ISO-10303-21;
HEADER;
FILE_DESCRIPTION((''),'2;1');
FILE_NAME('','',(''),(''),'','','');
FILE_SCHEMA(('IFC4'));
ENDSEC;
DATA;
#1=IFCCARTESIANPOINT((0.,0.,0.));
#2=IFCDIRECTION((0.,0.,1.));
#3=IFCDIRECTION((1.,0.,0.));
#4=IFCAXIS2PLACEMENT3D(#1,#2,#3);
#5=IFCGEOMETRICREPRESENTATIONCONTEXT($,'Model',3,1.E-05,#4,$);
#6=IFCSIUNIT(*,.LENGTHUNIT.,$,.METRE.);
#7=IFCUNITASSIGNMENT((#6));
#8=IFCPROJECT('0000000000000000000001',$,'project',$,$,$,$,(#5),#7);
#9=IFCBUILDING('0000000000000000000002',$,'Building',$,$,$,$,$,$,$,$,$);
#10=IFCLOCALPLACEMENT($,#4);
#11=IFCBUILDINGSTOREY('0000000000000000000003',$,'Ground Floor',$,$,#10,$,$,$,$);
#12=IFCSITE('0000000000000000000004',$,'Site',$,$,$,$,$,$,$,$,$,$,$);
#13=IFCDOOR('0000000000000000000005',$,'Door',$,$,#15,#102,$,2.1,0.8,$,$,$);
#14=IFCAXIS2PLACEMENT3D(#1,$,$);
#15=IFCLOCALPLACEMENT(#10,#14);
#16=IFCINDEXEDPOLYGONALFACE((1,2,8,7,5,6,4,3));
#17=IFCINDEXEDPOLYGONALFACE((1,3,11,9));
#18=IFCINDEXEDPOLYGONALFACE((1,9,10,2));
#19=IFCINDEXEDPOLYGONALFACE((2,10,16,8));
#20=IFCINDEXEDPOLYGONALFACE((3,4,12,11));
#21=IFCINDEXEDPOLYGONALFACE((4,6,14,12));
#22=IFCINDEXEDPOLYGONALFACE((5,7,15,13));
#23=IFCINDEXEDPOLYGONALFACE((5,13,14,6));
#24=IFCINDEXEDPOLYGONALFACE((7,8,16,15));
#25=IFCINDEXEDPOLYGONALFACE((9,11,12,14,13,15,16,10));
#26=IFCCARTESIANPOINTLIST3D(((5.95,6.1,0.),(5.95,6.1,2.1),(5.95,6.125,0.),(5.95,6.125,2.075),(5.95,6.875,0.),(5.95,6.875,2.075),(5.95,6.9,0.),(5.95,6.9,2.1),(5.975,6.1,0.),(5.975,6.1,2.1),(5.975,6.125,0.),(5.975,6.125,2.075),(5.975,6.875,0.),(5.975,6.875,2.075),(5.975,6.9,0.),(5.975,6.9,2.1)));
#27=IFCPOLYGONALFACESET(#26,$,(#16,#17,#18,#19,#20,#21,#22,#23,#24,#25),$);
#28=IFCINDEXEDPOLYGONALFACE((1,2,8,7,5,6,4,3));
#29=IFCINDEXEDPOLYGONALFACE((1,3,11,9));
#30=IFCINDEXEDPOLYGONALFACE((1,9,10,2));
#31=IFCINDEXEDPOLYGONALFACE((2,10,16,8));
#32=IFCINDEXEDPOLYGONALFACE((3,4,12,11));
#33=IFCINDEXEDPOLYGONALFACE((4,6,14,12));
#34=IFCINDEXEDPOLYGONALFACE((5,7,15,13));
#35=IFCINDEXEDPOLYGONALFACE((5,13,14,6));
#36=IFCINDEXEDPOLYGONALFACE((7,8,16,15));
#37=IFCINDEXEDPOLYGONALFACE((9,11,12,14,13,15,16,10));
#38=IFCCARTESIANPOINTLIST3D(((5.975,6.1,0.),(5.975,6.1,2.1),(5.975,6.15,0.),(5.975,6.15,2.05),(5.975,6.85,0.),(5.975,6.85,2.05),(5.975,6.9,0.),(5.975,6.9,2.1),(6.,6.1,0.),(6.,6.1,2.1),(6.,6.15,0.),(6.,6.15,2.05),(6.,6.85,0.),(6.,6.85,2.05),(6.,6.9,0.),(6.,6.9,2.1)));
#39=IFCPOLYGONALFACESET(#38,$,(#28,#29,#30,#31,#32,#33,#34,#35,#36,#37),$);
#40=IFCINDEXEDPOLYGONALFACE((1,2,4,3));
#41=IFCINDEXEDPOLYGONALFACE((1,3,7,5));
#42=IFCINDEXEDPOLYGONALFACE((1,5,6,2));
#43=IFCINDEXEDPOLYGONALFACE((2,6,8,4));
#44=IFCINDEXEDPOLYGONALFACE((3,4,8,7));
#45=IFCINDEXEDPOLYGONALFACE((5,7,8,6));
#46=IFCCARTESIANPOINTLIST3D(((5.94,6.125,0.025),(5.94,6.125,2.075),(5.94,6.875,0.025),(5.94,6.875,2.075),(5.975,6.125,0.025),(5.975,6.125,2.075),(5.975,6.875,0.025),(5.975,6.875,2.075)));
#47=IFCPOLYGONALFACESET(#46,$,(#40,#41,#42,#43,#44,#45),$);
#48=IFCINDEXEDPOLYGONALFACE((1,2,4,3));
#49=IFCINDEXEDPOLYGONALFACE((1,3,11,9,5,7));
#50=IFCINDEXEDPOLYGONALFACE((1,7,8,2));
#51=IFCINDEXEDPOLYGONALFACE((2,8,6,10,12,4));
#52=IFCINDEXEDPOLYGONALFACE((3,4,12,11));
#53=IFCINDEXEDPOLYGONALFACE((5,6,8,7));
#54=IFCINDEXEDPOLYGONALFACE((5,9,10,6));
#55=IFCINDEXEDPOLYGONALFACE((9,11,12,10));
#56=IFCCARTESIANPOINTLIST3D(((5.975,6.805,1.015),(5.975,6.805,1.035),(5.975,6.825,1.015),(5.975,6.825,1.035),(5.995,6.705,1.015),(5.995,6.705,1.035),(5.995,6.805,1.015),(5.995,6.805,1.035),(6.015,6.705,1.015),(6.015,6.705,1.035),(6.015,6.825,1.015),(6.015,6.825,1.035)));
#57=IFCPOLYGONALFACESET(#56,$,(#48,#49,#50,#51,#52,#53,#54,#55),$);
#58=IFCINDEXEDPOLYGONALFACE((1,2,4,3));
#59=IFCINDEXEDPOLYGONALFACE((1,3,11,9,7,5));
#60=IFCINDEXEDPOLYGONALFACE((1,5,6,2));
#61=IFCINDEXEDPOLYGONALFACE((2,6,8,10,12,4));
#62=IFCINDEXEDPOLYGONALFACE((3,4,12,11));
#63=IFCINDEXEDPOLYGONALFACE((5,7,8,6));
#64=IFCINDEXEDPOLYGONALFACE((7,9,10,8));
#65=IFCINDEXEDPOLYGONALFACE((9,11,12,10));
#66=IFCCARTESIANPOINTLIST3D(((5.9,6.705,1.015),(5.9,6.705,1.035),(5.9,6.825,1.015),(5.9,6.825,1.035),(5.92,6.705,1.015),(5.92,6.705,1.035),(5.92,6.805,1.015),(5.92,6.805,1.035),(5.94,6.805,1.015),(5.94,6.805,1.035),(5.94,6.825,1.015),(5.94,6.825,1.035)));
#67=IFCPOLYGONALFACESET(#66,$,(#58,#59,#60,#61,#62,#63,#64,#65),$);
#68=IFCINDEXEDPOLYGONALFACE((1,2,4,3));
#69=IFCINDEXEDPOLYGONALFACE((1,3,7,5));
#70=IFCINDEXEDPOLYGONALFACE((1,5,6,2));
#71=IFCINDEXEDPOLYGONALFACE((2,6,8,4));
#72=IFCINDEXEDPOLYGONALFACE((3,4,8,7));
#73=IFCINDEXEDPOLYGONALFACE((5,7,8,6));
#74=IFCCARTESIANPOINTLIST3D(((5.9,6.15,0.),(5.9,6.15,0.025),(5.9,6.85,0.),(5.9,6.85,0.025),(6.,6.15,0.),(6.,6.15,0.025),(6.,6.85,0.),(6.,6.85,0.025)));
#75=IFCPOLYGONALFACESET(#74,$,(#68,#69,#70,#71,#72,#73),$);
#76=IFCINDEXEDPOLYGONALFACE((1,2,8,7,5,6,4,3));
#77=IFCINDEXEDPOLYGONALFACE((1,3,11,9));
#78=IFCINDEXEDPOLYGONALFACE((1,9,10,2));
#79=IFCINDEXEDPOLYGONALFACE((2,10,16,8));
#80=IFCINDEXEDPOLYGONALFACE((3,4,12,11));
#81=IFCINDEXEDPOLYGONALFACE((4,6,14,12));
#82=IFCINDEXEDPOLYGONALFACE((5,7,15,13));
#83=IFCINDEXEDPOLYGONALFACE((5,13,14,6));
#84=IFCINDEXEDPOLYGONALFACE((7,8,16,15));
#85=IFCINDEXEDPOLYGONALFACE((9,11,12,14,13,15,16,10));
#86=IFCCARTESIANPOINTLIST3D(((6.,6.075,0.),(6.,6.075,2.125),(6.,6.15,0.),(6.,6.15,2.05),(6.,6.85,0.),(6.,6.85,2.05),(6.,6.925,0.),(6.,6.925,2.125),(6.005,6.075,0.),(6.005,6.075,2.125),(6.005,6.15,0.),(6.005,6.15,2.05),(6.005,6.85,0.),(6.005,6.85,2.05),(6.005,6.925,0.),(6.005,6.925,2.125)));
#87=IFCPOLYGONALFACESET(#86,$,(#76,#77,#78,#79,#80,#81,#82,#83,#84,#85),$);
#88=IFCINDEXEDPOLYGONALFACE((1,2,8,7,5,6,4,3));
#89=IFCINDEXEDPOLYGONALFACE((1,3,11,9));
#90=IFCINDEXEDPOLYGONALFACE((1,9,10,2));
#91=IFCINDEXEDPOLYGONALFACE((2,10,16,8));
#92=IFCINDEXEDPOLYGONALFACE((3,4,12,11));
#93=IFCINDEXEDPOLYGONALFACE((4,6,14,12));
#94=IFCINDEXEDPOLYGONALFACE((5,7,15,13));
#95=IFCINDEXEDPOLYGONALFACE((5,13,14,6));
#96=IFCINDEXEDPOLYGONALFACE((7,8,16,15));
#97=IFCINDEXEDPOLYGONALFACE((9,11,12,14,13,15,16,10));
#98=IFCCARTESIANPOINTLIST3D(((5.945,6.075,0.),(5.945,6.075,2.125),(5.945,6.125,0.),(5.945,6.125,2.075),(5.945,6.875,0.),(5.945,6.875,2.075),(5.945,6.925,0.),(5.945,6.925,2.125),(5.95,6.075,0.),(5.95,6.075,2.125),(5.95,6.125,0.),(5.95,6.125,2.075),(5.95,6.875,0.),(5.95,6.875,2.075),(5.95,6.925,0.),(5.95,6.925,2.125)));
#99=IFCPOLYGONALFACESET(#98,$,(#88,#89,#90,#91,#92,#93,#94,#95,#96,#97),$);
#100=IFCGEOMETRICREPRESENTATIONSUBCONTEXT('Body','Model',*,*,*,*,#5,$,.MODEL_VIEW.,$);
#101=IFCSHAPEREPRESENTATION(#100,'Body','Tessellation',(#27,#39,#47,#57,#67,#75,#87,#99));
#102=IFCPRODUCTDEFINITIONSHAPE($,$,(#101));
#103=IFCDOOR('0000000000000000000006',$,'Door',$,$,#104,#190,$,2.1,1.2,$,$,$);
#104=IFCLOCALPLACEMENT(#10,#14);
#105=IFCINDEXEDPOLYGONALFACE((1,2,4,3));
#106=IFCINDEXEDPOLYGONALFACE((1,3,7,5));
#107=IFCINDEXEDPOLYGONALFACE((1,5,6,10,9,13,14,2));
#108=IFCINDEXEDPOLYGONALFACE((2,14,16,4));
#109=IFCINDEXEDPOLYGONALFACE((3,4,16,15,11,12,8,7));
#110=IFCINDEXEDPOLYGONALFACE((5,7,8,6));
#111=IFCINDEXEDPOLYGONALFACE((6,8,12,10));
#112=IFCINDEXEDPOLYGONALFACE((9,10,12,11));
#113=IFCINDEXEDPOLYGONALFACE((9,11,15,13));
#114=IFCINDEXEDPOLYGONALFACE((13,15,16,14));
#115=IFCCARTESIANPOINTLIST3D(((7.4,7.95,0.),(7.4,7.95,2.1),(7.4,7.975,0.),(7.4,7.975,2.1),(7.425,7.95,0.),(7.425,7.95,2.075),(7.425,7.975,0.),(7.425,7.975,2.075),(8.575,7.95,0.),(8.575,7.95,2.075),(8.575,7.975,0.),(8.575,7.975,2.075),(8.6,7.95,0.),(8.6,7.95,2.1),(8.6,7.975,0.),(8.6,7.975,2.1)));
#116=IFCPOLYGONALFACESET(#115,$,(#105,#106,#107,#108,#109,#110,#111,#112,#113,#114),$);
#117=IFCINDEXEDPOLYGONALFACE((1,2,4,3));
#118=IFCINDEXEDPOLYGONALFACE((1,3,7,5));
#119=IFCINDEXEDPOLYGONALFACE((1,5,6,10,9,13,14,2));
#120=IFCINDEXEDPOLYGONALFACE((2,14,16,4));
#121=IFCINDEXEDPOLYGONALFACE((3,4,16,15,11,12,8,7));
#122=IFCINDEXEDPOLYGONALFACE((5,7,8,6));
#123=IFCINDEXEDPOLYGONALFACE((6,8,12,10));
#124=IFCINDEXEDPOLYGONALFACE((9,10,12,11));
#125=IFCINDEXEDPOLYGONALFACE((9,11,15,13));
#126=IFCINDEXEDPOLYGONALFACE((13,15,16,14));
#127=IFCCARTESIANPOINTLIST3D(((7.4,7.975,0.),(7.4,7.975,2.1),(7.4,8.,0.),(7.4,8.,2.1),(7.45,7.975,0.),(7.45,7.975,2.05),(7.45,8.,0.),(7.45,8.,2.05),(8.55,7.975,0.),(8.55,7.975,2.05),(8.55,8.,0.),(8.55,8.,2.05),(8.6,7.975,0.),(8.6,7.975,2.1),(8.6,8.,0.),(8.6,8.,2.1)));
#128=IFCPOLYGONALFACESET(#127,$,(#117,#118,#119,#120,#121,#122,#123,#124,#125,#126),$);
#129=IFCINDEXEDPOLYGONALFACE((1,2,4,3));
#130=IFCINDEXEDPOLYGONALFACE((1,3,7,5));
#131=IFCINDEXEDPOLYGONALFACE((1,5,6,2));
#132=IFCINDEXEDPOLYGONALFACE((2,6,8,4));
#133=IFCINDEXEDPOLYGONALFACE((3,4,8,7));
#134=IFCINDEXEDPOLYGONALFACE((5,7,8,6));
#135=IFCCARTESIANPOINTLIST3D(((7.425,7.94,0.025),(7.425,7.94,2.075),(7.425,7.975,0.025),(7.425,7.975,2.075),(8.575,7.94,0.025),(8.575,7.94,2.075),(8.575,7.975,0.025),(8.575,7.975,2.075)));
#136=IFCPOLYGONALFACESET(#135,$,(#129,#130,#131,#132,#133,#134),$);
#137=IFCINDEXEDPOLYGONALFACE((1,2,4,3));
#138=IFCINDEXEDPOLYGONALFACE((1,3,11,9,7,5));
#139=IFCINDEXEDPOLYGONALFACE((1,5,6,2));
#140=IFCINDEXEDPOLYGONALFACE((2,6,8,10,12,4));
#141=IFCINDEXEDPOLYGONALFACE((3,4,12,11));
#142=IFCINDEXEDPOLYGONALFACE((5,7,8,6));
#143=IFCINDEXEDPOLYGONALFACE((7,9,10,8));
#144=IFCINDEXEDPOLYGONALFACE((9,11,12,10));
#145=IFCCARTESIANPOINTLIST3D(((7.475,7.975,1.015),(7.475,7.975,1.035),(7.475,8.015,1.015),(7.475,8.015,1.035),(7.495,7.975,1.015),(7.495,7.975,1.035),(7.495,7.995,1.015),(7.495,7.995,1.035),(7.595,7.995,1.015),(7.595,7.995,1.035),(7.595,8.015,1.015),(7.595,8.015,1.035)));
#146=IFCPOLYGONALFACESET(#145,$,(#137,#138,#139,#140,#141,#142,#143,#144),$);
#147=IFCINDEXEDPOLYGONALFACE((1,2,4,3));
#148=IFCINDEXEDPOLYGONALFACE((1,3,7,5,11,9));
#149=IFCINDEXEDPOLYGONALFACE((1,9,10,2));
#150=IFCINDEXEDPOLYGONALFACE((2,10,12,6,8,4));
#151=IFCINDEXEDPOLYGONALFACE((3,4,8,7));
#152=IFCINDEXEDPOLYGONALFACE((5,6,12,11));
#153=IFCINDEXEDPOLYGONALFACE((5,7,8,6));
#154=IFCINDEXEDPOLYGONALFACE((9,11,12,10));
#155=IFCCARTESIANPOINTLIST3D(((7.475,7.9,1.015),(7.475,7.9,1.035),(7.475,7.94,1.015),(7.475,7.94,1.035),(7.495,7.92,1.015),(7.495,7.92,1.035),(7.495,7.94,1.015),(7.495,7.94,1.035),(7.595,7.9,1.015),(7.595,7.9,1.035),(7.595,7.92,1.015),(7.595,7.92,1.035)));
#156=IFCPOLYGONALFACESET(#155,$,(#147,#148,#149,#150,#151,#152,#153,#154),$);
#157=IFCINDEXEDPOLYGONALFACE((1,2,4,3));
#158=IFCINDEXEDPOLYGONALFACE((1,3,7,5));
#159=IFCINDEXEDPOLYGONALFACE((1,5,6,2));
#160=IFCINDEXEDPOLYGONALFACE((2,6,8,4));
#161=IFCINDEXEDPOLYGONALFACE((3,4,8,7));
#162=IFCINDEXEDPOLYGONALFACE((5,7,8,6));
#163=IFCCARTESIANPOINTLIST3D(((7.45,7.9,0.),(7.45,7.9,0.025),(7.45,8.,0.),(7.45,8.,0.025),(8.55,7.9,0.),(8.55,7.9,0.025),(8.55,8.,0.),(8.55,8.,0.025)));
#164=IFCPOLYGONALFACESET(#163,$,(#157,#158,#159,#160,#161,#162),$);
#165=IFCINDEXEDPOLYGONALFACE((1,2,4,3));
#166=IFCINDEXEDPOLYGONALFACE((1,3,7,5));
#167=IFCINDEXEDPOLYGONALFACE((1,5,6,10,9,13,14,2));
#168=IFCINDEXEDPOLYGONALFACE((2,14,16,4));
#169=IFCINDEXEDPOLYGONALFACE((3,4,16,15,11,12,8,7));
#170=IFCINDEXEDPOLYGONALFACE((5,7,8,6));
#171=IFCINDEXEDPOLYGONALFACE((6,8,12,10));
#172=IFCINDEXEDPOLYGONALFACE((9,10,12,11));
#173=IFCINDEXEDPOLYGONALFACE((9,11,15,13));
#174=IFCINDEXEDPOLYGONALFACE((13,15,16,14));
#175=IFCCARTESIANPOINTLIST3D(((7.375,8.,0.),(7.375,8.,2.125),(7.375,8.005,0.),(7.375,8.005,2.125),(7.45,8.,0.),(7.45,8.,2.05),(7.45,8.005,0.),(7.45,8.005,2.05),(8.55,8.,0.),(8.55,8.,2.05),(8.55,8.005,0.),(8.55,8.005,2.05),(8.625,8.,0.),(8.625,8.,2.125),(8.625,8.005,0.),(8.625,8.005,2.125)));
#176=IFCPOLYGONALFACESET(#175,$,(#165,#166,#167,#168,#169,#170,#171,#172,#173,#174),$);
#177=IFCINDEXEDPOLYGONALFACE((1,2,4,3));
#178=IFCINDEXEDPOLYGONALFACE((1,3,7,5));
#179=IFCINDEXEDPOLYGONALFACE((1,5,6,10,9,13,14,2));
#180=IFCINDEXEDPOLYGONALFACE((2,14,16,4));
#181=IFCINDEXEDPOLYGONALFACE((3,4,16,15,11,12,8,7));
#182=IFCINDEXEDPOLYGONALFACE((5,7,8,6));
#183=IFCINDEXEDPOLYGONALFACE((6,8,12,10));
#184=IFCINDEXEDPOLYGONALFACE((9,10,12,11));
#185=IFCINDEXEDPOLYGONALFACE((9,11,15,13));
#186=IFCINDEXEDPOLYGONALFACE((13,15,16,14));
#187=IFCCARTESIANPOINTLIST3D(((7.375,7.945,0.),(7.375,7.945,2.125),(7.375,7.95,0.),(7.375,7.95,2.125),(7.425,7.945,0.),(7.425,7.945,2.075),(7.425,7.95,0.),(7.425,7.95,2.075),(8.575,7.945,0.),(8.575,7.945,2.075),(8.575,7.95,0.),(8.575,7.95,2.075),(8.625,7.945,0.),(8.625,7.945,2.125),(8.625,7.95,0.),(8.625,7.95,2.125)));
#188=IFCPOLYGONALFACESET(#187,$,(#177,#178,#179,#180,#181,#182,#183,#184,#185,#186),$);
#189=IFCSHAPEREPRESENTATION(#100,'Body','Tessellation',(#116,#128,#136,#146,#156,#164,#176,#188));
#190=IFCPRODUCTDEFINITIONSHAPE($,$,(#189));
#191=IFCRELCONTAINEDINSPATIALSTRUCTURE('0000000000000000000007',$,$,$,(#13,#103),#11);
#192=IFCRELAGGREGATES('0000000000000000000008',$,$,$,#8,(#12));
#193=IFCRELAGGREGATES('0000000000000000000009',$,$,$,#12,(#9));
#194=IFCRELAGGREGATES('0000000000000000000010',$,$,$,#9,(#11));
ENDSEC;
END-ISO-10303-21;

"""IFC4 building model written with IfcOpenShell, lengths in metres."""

from ifc_helpers import new_model, si_unit, frame, origin_with_axes, place, context, subcontext, project, spatial, line, indexed_curve, outline, extrude, element, save


model = new_model("IFC4")

# Units and contexts
model_context = context("Model", 3, precision=1e-05, world=origin_with_axes())
body_context = subcontext(model_context, "Body", "Model", "MODEL_VIEW")
ifc_project = project(units=[si_unit("LENGTHUNIT", "METRE")], contexts=[model_context])

# Site, building, storey
site = spatial("IfcSite", under=ifc_project, Name="Site")
building = spatial("IfcBuilding", under=site, Name="Building")
storey_placement = place(None, origin_with_axes())
storey = spatial("IfcBuildingStorey", under=building, at=storey_placement, Name="Ground Floor")

# Doors
door_1_placement = place(storey_placement, frame((6.0, 6.1, 0.0), z_axis=(0.0, 0.0, 1.0), x_axis=(0.0, 1.0, 0.0)))
element("IfcDoor", 1, at=door_1_placement, inside=storey, Name="Door", OverallHeight=2.1, OverallWidth=0.8, context=body_context, shape_type="SweptSolid", body=[
    extrude(outline(indexed_curve([(0.0, 0.0), (0.0, 2.1), (0.8, 2.1), (0.8, 0.0), (0.775, 0.0), (0.775, 2.075), (0.025, 2.075), (0.025, 0.0)], segments=[line(1, 2, 3, 4, 5, 6, 7, 8, 1)])), frame((0.0, 0.025, 0.0), z_axis=(0.0, -1.0, 0.0), x_axis=(1.0, 0.0, 0.0)), (0.0, 0.0, -1.0), 0.025),
    extrude(outline(indexed_curve([(0.0, 0.0), (0.0, 2.1), (0.8, 2.1), (0.8, 0.0), (0.75, 0.0), (0.75, 2.05), (0.05, 2.05), (0.05, 0.0)], segments=[line(1, 2, 3, 4, 5, 6, 7, 8, 1)])), frame((0.0, 0.0, 0.0), z_axis=(0.0, -1.0, 0.0), x_axis=(1.0, 0.0, 0.0)), (0.0, 0.0, -1.0), 0.025),
    extrude(outline(indexed_curve([(0.0, 0.0), (0.75, 0.0), (0.75, 0.035), (0.0, 0.035)], segments=[line(1, 2, 3, 4, 1)])), frame((0.025, 0.025, 0.025), z_axis=(0.0, 0.0, 1.0), x_axis=(1.0, 0.0, 0.0)), (0.0, 0.0, 1.0), 2.05),
    extrude(outline(indexed_curve([(0.0, 0.0), (0.0, -0.04), (-0.12, -0.04), (-0.12, -0.02), (-0.02, -0.02), (-0.02, 0.0)], segments=[line(1, 2, 3, 4, 5, 6, 1)])), frame((0.725, 0.025, 1.015), z_axis=(0.0, 0.0, 1.0), x_axis=(1.0, 0.0, 0.0)), (0.0, 0.0, 1.0), 0.02),
    extrude(outline(indexed_curve([(0.0, 0.0), (0.0, 0.04), (-0.12, 0.04), (-0.12, 0.02), (-0.02, 0.02), (-0.02, 0.0)], segments=[line(1, 2, 3, 4, 5, 6, 1)])), frame((0.725, 0.06, 1.015), z_axis=(0.0, 0.0, 1.0), x_axis=(1.0, 0.0, 0.0)), (0.0, 0.0, 1.0), 0.02),
    extrude(outline(indexed_curve([(0.0, 0.0), (0.7, 0.0), (0.7, 0.1), (0.0, 0.1)], segments=[line(1, 2, 3, 4, 1)])), frame((0.05, 0.0, 0.0), z_axis=(0.0, 0.0, 1.0), x_axis=(1.0, 0.0, 0.0)), (0.0, 0.0, 1.0), 0.025),
    extrude(outline(indexed_curve([(0.0, 0.0), (0.0, 2.125), (0.85, 2.125), (0.85, 0.0), (0.775, 0.0), (0.775, 2.05), (0.075, 2.05), (0.075, 0.0)], segments=[line(1, 2, 3, 4, 5, 6, 7, 8, 1)])), frame((-0.025, -0.005, 0.0), z_axis=(0.0, -1.0, 0.0), x_axis=(1.0, 0.0, 0.0)), (0.0, 0.0, -1.0), 0.005),
    extrude(outline(indexed_curve([(0.0, 0.0), (0.0, 2.125), (0.85, 2.125), (0.85, 0.0), (0.8, 0.0), (0.8, 2.075), (0.05, 2.075), (0.05, 0.0)], segments=[line(1, 2, 3, 4, 5, 6, 7, 8, 1)])), frame((-0.025, 0.05, 0.0), z_axis=(0.0, -1.0, 0.0), x_axis=(1.0, 0.0, 0.0)), (0.0, 0.0, -1.0), 0.005),
])
door_2_placement = place(storey_placement, frame((8.6, 8.0, 0.0), z_axis=(0.0, 0.0, 1.0), x_axis=(-1.0, 0.0, 0.0)))
element("IfcDoor", 2, at=door_2_placement, inside=storey, Name="Door", OverallHeight=2.1, OverallWidth=1.2, context=body_context, shape_type="SweptSolid", body=[
    extrude(outline(indexed_curve([(0.0, 0.0), (0.0, 2.1), (1.2, 2.1), (1.2, 0.0), (1.175, 0.0), (1.175, 2.075), (0.025, 2.075), (0.025, 0.0)], segments=[line(1, 2, 3, 4, 5, 6, 7, 8, 1)])), frame((0.0, 0.025, 0.0), z_axis=(0.0, -1.0, 0.0), x_axis=(1.0, 0.0, 0.0)), (0.0, 0.0, -1.0), 0.025),
    extrude(outline(indexed_curve([(0.0, 0.0), (0.0, 2.1), (1.2, 2.1), (1.2, 0.0), (1.15, 0.0), (1.15, 2.05), (0.05, 2.05), (0.05, 0.0)], segments=[line(1, 2, 3, 4, 5, 6, 7, 8, 1)])), frame((0.0, 0.0, 0.0), z_axis=(0.0, -1.0, 0.0), x_axis=(1.0, 0.0, 0.0)), (0.0, 0.0, -1.0), 0.025),
    extrude(outline(indexed_curve([(0.0, 0.0), (1.15, 0.0), (1.15, 0.035), (0.0, 0.035)], segments=[line(1, 2, 3, 4, 1)])), frame((0.025, 0.025, 0.025), z_axis=(0.0, 0.0, 1.0), x_axis=(1.0, 0.0, 0.0)), (0.0, 0.0, 1.0), 2.05),
    extrude(outline(indexed_curve([(0.0, 0.0), (0.0, -0.04), (-0.12, -0.04), (-0.12, -0.02), (-0.02, -0.02), (-0.02, 0.0)], segments=[line(1, 2, 3, 4, 5, 6, 1)])), frame((1.125, 0.025, 1.015), z_axis=(0.0, 0.0, 1.0), x_axis=(1.0, 0.0, 0.0)), (0.0, 0.0, 1.0), 0.02),
    extrude(outline(indexed_curve([(0.0, 0.0), (0.0, 0.04), (-0.12, 0.04), (-0.12, 0.02), (-0.02, 0.02), (-0.02, 0.0)], segments=[line(1, 2, 3, 4, 5, 6, 1)])), frame((1.125, 0.06, 1.015), z_axis=(0.0, 0.0, 1.0), x_axis=(1.0, 0.0, 0.0)), (0.0, 0.0, 1.0), 0.02),
    extrude(outline(indexed_curve([(0.0, 0.0), (1.1, 0.0), (1.1, 0.1), (0.0, 0.1)], segments=[line(1, 2, 3, 4, 1)])), frame((0.05, 0.0, 0.0), z_axis=(0.0, 0.0, 1.0), x_axis=(1.0, 0.0, 0.0)), (0.0, 0.0, 1.0), 0.025),
    extrude(outline(indexed_curve([(0.0, 0.0), (0.0, 2.125), (1.25, 2.125), (1.25, 0.0), (1.175, 0.0), (1.175, 2.05), (0.075, 2.05), (0.075, 0.0)], segments=[line(1, 2, 3, 4, 5, 6, 7, 8, 1)])), frame((-0.025, -0.005, 0.0), z_axis=(0.0, -1.0, 0.0), x_axis=(1.0, 0.0, 0.0)), (0.0, 0.0, -1.0), 0.005),
    extrude(outline(indexed_curve([(0.0, 0.0), (0.0, 2.125), (1.25, 2.125), (1.25, 0.0), (1.2, 0.0), (1.2, 2.075), (0.05, 2.075), (0.05, 0.0)], segments=[line(1, 2, 3, 4, 5, 6, 7, 8, 1)])), frame((-0.025, 0.05, 0.0), z_axis=(0.0, -1.0, 0.0), x_axis=(1.0, 0.0, 0.0)), (0.0, 0.0, -1.0), 0.005),
])

save(model, "model.ifc")
